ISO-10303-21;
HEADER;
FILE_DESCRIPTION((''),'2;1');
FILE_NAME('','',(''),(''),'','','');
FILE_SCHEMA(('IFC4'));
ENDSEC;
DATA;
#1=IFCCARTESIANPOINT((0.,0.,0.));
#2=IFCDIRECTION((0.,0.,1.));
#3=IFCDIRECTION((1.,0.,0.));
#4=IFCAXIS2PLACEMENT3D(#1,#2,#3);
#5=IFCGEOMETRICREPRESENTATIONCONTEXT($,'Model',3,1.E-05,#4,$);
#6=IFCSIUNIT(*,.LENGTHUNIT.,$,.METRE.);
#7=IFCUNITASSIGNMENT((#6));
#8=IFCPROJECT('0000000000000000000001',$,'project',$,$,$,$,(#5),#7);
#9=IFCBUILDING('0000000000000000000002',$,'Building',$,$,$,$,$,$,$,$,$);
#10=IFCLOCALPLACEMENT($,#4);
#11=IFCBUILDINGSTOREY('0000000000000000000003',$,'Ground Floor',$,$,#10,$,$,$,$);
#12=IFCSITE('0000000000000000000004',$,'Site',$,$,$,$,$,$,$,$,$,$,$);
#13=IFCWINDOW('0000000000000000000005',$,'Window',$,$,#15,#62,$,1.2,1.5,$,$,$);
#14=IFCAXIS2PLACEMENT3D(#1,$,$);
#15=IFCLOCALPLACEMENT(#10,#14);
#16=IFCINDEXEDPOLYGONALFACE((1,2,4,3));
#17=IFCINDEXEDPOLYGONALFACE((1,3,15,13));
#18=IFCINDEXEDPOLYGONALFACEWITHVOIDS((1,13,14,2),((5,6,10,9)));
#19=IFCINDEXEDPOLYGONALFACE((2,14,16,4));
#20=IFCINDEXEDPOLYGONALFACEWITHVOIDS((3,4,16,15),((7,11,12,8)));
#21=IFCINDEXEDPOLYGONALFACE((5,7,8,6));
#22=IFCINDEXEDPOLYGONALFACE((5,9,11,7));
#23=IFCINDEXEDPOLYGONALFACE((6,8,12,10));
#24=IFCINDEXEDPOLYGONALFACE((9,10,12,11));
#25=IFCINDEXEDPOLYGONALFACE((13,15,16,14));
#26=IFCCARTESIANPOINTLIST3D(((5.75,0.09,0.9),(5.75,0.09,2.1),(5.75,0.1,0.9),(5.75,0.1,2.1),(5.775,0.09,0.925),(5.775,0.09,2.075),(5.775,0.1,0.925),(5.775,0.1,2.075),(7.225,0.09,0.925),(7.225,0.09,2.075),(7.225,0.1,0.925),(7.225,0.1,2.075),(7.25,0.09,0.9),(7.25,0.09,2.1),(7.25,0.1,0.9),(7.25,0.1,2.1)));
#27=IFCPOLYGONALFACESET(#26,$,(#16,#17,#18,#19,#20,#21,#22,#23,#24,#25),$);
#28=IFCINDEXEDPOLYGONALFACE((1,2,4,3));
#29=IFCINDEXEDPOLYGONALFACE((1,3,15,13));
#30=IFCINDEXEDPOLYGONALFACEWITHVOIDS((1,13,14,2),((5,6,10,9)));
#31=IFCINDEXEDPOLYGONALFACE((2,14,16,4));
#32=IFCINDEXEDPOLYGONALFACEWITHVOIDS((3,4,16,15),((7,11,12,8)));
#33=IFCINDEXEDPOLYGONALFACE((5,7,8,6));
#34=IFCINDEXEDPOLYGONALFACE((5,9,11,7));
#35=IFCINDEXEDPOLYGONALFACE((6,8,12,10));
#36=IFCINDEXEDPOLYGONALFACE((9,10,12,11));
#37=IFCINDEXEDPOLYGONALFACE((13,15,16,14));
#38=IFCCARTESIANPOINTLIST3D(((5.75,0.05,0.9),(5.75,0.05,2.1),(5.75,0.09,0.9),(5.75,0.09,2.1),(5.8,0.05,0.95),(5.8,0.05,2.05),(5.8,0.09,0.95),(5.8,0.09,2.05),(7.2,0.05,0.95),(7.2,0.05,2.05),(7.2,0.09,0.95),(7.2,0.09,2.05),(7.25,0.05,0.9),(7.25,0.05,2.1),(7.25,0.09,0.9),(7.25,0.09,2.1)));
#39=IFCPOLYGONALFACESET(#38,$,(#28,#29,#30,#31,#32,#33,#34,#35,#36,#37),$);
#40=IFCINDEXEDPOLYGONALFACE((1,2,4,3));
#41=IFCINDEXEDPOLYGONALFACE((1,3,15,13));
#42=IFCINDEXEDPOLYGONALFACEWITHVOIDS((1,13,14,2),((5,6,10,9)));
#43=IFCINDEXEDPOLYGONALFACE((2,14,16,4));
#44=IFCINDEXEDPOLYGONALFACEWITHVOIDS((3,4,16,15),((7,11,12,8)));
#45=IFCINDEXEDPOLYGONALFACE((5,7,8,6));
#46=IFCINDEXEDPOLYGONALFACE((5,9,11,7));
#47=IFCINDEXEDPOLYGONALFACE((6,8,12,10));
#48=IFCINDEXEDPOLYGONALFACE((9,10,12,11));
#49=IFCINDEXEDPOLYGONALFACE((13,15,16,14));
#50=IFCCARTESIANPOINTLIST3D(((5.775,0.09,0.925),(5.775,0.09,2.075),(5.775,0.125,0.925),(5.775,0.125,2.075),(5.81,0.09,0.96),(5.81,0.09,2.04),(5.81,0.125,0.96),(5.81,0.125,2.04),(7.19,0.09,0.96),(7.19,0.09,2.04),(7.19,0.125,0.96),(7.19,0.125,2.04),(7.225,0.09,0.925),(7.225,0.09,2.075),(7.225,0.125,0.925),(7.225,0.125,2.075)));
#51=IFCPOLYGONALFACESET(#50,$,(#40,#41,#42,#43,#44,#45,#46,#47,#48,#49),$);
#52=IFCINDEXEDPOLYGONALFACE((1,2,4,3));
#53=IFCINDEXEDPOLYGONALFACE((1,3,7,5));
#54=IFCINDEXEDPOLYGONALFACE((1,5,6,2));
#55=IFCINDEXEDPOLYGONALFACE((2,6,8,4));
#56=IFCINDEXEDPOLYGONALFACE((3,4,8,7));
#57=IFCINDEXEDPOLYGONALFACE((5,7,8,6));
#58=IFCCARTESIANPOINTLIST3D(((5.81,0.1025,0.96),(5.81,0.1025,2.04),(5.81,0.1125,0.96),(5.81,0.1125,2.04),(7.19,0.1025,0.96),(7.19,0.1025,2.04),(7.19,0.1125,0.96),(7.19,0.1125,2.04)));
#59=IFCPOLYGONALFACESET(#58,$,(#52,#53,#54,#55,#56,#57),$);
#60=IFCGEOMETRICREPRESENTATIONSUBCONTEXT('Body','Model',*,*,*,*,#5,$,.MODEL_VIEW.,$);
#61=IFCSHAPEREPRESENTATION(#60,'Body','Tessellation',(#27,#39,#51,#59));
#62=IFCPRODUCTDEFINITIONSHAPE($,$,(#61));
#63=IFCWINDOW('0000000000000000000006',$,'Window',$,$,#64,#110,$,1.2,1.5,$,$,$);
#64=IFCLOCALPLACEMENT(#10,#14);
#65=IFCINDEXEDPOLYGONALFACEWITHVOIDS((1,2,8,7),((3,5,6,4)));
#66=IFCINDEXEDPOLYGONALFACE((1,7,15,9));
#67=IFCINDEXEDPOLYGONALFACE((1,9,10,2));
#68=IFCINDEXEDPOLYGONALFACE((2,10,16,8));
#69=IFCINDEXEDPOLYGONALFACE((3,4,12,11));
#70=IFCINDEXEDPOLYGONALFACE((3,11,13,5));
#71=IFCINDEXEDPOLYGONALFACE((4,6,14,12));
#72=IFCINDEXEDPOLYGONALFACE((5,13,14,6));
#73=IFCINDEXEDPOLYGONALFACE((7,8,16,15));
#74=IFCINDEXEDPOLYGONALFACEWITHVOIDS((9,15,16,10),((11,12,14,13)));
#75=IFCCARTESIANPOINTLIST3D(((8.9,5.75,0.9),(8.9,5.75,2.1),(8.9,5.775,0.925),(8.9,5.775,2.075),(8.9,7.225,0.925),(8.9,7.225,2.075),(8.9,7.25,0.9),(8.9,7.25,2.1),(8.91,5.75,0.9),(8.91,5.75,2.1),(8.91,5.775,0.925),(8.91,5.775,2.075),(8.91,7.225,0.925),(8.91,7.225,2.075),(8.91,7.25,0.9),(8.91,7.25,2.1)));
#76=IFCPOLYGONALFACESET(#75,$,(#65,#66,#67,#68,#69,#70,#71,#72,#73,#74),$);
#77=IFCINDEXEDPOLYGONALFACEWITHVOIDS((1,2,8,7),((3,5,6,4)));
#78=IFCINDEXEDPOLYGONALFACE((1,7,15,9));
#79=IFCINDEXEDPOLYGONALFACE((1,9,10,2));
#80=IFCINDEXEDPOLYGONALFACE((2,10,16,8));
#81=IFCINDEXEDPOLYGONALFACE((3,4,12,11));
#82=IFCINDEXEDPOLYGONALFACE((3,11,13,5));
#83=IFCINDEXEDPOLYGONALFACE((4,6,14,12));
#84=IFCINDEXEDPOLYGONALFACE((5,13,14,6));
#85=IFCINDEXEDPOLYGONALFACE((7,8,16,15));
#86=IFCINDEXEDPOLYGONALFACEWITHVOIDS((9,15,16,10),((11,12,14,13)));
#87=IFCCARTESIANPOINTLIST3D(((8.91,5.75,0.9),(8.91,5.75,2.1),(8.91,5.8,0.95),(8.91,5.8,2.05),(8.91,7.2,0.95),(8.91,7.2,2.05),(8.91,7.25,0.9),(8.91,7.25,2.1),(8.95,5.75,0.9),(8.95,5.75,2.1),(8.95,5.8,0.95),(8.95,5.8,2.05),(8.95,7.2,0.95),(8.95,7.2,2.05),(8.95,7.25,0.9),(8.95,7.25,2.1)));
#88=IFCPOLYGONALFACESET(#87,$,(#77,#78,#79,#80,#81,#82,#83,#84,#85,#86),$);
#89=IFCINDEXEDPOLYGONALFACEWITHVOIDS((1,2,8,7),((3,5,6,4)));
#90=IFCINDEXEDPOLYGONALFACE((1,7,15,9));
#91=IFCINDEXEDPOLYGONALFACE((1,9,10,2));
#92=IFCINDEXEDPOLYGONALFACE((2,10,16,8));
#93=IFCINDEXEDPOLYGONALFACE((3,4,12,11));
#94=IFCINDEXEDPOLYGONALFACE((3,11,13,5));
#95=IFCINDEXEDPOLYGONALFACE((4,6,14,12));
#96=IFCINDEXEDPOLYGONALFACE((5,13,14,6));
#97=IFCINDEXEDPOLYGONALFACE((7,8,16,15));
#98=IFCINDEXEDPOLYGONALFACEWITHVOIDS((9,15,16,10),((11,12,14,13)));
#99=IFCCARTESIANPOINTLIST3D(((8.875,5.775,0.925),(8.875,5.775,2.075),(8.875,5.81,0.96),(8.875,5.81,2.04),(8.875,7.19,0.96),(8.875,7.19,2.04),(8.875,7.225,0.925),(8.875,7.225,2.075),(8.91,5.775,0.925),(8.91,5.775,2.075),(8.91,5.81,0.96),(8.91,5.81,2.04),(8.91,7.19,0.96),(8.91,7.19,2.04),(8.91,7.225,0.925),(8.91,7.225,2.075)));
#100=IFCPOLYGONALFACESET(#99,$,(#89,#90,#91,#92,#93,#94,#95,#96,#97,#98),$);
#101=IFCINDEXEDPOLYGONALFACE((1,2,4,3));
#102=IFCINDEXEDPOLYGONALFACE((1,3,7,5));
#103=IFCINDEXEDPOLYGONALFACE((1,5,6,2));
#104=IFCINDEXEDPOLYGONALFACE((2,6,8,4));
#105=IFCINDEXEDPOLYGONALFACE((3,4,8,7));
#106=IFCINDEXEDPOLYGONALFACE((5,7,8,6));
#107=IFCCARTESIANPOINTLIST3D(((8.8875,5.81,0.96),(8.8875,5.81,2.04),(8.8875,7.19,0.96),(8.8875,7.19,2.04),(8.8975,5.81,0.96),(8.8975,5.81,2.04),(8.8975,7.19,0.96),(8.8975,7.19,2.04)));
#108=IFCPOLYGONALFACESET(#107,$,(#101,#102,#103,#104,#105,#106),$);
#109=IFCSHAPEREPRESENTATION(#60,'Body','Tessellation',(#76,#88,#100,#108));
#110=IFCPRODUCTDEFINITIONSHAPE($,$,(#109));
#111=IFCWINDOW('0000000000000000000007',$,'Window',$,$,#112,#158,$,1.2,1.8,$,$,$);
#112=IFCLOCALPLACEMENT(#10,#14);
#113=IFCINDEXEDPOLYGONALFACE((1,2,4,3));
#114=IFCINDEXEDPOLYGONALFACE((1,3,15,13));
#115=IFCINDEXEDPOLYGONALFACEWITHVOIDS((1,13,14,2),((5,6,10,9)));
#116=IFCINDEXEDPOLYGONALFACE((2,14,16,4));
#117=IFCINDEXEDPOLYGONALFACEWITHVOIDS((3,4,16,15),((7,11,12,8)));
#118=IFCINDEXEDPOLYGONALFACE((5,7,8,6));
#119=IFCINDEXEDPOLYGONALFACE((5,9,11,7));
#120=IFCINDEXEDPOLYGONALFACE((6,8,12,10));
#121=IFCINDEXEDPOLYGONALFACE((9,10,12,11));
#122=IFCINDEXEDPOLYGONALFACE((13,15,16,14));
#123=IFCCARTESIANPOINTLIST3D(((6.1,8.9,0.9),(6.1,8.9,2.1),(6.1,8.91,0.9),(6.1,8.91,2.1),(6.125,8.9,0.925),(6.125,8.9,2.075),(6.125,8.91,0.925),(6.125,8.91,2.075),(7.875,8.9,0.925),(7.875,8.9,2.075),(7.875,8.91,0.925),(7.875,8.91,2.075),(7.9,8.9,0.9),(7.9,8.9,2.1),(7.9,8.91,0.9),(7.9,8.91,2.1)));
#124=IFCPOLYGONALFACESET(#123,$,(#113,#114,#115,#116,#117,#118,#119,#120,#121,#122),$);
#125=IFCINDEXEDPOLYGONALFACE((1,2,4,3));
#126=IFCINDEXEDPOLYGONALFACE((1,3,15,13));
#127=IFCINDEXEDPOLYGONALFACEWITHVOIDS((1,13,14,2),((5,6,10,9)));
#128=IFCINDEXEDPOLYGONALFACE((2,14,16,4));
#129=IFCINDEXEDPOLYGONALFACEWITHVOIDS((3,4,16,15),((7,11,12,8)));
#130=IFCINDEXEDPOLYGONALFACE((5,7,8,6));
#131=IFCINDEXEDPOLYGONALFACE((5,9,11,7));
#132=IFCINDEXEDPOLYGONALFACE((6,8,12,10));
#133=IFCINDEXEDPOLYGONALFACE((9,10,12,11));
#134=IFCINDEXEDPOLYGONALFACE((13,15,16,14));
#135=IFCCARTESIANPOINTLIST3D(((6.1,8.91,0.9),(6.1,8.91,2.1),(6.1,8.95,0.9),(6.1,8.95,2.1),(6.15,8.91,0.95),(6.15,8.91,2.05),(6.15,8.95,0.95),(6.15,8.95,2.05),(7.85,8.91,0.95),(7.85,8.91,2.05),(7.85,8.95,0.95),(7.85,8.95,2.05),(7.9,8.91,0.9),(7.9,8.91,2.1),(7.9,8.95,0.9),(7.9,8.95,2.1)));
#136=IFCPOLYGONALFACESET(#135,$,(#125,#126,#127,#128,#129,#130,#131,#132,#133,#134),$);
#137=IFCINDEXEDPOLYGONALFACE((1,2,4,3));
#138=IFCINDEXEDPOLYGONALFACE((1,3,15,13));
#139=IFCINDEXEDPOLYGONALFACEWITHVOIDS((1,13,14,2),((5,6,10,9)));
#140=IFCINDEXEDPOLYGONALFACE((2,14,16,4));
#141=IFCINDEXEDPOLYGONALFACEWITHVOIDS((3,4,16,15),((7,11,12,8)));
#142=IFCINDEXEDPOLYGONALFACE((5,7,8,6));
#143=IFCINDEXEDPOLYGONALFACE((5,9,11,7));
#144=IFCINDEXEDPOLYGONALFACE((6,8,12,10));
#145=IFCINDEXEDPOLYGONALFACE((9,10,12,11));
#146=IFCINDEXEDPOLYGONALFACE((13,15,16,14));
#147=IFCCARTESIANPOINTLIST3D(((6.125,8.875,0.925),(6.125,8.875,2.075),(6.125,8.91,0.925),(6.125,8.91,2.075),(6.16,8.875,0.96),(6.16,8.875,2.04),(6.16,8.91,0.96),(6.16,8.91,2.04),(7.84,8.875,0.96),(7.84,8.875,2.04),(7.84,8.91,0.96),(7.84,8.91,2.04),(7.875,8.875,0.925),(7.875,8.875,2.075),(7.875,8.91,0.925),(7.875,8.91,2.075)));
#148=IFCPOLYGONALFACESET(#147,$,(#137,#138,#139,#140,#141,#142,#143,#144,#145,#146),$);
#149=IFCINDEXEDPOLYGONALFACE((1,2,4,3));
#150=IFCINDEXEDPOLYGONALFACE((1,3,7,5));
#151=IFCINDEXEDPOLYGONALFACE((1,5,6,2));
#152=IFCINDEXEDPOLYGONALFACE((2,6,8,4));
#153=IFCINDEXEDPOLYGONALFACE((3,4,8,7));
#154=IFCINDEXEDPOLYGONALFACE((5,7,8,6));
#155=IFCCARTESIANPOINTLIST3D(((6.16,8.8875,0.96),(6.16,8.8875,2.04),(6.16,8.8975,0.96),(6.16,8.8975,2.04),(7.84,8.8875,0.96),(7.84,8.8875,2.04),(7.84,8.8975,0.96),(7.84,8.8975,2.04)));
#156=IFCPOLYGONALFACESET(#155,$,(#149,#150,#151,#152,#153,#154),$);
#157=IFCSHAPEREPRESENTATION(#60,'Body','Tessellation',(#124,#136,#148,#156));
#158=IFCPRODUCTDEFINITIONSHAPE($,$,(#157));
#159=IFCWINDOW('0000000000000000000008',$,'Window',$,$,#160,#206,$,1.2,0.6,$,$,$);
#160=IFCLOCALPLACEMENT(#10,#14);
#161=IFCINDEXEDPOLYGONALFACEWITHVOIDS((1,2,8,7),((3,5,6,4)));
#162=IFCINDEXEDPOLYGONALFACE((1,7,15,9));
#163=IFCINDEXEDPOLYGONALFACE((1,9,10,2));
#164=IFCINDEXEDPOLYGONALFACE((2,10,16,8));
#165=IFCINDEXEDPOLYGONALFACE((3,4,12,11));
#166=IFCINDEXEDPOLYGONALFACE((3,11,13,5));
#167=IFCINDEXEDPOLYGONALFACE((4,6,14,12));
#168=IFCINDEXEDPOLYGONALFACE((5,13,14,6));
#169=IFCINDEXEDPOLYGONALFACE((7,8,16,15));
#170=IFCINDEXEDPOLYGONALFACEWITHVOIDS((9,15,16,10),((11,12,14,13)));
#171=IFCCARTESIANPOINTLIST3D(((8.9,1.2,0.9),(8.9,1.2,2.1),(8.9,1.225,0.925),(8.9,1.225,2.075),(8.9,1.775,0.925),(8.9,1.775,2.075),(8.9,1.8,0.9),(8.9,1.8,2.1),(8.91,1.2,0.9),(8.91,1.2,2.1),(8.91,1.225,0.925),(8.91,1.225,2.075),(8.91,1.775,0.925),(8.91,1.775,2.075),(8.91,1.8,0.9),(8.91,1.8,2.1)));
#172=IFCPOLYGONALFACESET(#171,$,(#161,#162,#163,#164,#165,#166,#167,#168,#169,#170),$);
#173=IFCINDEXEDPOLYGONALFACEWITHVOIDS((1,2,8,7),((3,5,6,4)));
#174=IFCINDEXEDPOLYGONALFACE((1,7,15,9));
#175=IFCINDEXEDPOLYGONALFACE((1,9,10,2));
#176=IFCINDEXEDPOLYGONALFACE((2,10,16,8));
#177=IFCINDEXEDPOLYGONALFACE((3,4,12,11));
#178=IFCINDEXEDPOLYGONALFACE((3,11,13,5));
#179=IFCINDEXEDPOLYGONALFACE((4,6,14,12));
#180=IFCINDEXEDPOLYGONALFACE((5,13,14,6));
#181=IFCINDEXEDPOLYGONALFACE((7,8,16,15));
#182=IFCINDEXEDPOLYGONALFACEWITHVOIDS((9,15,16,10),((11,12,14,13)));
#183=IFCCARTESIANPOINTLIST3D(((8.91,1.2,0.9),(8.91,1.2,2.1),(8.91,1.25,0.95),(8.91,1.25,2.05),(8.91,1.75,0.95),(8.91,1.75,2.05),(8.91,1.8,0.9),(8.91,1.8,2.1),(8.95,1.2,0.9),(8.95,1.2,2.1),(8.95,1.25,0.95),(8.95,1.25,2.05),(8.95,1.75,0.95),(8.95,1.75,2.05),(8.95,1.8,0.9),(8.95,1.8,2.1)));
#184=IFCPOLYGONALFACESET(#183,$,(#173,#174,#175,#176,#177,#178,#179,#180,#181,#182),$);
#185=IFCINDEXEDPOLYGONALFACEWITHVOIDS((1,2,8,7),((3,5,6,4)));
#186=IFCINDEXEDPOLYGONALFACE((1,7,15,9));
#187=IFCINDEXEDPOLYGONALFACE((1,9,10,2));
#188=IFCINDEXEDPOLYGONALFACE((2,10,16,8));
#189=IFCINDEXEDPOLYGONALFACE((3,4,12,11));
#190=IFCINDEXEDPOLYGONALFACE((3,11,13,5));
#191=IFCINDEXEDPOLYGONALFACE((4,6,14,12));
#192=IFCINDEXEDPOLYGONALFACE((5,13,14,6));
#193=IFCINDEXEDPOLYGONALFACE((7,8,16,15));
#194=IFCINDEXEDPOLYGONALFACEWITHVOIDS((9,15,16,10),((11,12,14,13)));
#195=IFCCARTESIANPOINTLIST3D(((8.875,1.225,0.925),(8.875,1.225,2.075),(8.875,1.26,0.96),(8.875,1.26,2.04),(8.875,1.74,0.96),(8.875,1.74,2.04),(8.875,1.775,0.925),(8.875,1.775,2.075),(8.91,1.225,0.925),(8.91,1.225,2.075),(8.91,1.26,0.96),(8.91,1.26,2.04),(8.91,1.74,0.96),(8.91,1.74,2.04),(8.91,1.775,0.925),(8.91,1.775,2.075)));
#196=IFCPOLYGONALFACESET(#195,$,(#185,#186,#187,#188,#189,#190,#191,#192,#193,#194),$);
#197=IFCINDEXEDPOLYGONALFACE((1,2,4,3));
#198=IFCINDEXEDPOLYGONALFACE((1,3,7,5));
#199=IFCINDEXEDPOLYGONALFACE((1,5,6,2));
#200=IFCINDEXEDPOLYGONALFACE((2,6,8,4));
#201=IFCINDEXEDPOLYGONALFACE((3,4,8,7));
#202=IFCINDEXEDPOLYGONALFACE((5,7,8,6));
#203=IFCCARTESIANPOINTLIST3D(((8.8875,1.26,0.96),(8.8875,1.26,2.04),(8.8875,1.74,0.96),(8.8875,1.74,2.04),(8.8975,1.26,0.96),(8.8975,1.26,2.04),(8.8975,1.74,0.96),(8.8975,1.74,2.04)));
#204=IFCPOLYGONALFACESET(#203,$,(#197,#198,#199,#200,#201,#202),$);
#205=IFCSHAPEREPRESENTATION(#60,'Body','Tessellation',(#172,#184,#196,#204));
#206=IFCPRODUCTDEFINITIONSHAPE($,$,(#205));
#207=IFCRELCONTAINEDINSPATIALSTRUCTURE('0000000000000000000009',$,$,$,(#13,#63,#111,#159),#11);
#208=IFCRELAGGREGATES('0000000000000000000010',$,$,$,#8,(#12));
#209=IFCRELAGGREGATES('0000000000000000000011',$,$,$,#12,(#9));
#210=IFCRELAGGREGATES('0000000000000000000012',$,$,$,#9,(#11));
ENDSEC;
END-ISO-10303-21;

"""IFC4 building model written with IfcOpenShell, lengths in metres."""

from ifc_helpers import new_model, si_unit, frame, origin_with_axes, place, context, subcontext, project, spatial, line, indexed_curve, outline, extrude, element, save


model = new_model("IFC4")

# Units and contexts
model_context = context("Model", 3, precision=1e-05, world=origin_with_axes())
body_context = subcontext(model_context, "Body", "Model", "MODEL_VIEW")
ifc_project = project(units=[si_unit("LENGTHUNIT", "METRE")], contexts=[model_context])

# Site, building, storey
site = spatial("IfcSite", under=ifc_project, Name="Site")
building = spatial("IfcBuilding", under=site, Name="Building")
storey_placement = place(None, origin_with_axes())
storey = spatial("IfcBuildingStorey", under=building, at=storey_placement, Name="Ground Floor")

# Windows
for number, where, z_axis, x_axis, name in (
    (1, (5.75, 0.0, 0.9), (0.0, 0.0, 1.0), (1.0, 0.0, 0.0), "Window"),
    (2, (9.0, 5.75, 0.9), (0.0, 0.0, 1.0), (0.0, 1.0, 0.0), "Window"),
):
    element("IfcWindow", number, at=place(storey_placement, frame(where, z_axis=z_axis, x_axis=x_axis)), inside=storey, Name=name, OverallHeight=1.2, OverallWidth=1.5, context=body_context, shape_type="SweptSolid", body=[
        extrude(outline(indexed_curve([(0.0, 0.0), (1.5, 0.0), (1.5, 1.2), (0.0, 1.2)], segments=[line(1, 2, 3, 4, 1)]), holes=[indexed_curve([(0.025, 0.025), (1.475, 0.025), (1.475, 1.175), (0.025, 1.175)], segments=[line(1, 2, 3, 4, 1)])]), frame((0.0, 0.09, 0.0), z_axis=(0.0, -1.0, 0.0), x_axis=(1.0, 0.0, 0.0)), (0.0, 0.0, -1.0), 0.01),
        extrude(outline(indexed_curve([(0.0, 0.0), (1.5, 0.0), (1.5, 1.2), (0.0, 1.2)], segments=[line(1, 2, 3, 4, 1)]), holes=[indexed_curve([(0.05, 0.05), (1.45, 0.05), (1.45, 1.15), (0.05, 1.15)], segments=[line(1, 2, 3, 4, 1)])]), frame((0.0, 0.05, 0.0), z_axis=(0.0, -1.0, 0.0), x_axis=(1.0, 0.0, 0.0)), (0.0, 0.0, -1.0), 0.04),
        extrude(outline(indexed_curve([(0.0, 0.0), (1.45, 0.0), (1.45, 1.15), (0.0, 1.15)], segments=[line(1, 2, 3, 4, 1)]), holes=[indexed_curve([(0.035, 0.035), (1.415, 0.035), (1.415, 1.115), (0.035, 1.115)], segments=[line(1, 2, 3, 4, 1)])]), frame((0.025, 0.09, 0.025), z_axis=(0.0, -1.0, 0.0), x_axis=(1.0, 0.0, 0.0)), (0.0, 0.0, -1.0), 0.035),
        extrude(outline(indexed_curve([(0.035, 0.035), (1.415, 0.035), (1.415, 1.115), (0.035, 1.115)], segments=[line(1, 2, 3, 4, 1)])), frame((0.025, 0.1025, 0.025), z_axis=(0.0, -1.0, 0.0), x_axis=(1.0, 0.0, 0.0)), (0.0, 0.0, -1.0), 0.01),
    ])
window_1_placement = place(storey_placement, frame((7.9, 9.0, 0.9), z_axis=(0.0, 0.0, 1.0), x_axis=(-1.0, 0.0, 0.0)))
element("IfcWindow", 3, at=window_1_placement, inside=storey, Name="Window", OverallHeight=1.2, OverallWidth=1.8, context=body_context, shape_type="SweptSolid", body=[
    extrude(outline(indexed_curve([(0.0, 0.0), (1.8, 0.0), (1.8, 1.2), (0.0, 1.2)], segments=[line(1, 2, 3, 4, 1)]), holes=[indexed_curve([(0.025, 0.025), (1.775, 0.025), (1.775, 1.175), (0.025, 1.175)], segments=[line(1, 2, 3, 4, 1)])]), frame((0.0, 0.09, 0.0), z_axis=(0.0, -1.0, 0.0), x_axis=(1.0, 0.0, 0.0)), (0.0, 0.0, -1.0), 0.01),
    extrude(outline(indexed_curve([(0.0, 0.0), (1.8, 0.0), (1.8, 1.2), (0.0, 1.2)], segments=[line(1, 2, 3, 4, 1)]), holes=[indexed_curve([(0.05, 0.05), (1.75, 0.05), (1.75, 1.15), (0.05, 1.15)], segments=[line(1, 2, 3, 4, 1)])]), frame((0.0, 0.05, 0.0), z_axis=(0.0, -1.0, 0.0), x_axis=(1.0, 0.0, 0.0)), (0.0, 0.0, -1.0), 0.04),
    extrude(outline(indexed_curve([(0.0, 0.0), (1.75, 0.0), (1.75, 1.15), (0.0, 1.15)], segments=[line(1, 2, 3, 4, 1)]), holes=[indexed_curve([(0.035, 0.035), (1.715, 0.035), (1.715, 1.115), (0.035, 1.115)], segments=[line(1, 2, 3, 4, 1)])]), frame((0.025, 0.09, 0.025), z_axis=(0.0, -1.0, 0.0), x_axis=(1.0, 0.0, 0.0)), (0.0, 0.0, -1.0), 0.035),
    extrude(outline(indexed_curve([(0.035, 0.035), (1.715, 0.035), (1.715, 1.115), (0.035, 1.115)], segments=[line(1, 2, 3, 4, 1)])), frame((0.025, 0.1025, 0.025), z_axis=(0.0, -1.0, 0.0), x_axis=(1.0, 0.0, 0.0)), (0.0, 0.0, -1.0), 0.01),
])
window_2_placement = place(storey_placement, frame((9.0, 1.2, 0.9), z_axis=(0.0, 0.0, 1.0), x_axis=(0.0, 1.0, 0.0)))
element("IfcWindow", 4, at=window_2_placement, inside=storey, Name="Window", OverallHeight=1.2, OverallWidth=0.6, context=body_context, shape_type="SweptSolid", body=[
    extrude(outline(indexed_curve([(0.0, 0.0), (0.6, 0.0), (0.6, 1.2), (0.0, 1.2)], segments=[line(1, 2, 3, 4, 1)]), holes=[indexed_curve([(0.025, 0.025), (0.575, 0.025), (0.575, 1.175), (0.025, 1.175)], segments=[line(1, 2, 3, 4, 1)])]), frame((0.0, 0.09, 0.0), z_axis=(0.0, -1.0, 0.0), x_axis=(1.0, 0.0, 0.0)), (0.0, 0.0, -1.0), 0.01),
    extrude(outline(indexed_curve([(0.0, 0.0), (0.6, 0.0), (0.6, 1.2), (0.0, 1.2)], segments=[line(1, 2, 3, 4, 1)]), holes=[indexed_curve([(0.05, 0.05), (0.55, 0.05), (0.55, 1.15), (0.05, 1.15)], segments=[line(1, 2, 3, 4, 1)])]), frame((0.0, 0.05, 0.0), z_axis=(0.0, -1.0, 0.0), x_axis=(1.0, 0.0, 0.0)), (0.0, 0.0, -1.0), 0.04),
    extrude(outline(indexed_curve([(0.0, 0.0), (0.55, 0.0), (0.55, 1.15), (0.0, 1.15)], segments=[line(1, 2, 3, 4, 1)]), holes=[indexed_curve([(0.035, 0.035), (0.515, 0.035), (0.515, 1.115), (0.035, 1.115)], segments=[line(1, 2, 3, 4, 1)])]), frame((0.025, 0.09, 0.025), z_axis=(0.0, -1.0, 0.0), x_axis=(1.0, 0.0, 0.0)), (0.0, 0.0, -1.0), 0.035),
    extrude(outline(indexed_curve([(0.035, 0.035), (0.515, 0.035), (0.515, 1.115), (0.035, 1.115)], segments=[line(1, 2, 3, 4, 1)])), frame((0.025, 0.1025, 0.025), z_axis=(0.0, -1.0, 0.0), x_axis=(1.0, 0.0, 0.0)), (0.0, 0.0, -1.0), 0.01),
])

save(model, "model.ifc")
